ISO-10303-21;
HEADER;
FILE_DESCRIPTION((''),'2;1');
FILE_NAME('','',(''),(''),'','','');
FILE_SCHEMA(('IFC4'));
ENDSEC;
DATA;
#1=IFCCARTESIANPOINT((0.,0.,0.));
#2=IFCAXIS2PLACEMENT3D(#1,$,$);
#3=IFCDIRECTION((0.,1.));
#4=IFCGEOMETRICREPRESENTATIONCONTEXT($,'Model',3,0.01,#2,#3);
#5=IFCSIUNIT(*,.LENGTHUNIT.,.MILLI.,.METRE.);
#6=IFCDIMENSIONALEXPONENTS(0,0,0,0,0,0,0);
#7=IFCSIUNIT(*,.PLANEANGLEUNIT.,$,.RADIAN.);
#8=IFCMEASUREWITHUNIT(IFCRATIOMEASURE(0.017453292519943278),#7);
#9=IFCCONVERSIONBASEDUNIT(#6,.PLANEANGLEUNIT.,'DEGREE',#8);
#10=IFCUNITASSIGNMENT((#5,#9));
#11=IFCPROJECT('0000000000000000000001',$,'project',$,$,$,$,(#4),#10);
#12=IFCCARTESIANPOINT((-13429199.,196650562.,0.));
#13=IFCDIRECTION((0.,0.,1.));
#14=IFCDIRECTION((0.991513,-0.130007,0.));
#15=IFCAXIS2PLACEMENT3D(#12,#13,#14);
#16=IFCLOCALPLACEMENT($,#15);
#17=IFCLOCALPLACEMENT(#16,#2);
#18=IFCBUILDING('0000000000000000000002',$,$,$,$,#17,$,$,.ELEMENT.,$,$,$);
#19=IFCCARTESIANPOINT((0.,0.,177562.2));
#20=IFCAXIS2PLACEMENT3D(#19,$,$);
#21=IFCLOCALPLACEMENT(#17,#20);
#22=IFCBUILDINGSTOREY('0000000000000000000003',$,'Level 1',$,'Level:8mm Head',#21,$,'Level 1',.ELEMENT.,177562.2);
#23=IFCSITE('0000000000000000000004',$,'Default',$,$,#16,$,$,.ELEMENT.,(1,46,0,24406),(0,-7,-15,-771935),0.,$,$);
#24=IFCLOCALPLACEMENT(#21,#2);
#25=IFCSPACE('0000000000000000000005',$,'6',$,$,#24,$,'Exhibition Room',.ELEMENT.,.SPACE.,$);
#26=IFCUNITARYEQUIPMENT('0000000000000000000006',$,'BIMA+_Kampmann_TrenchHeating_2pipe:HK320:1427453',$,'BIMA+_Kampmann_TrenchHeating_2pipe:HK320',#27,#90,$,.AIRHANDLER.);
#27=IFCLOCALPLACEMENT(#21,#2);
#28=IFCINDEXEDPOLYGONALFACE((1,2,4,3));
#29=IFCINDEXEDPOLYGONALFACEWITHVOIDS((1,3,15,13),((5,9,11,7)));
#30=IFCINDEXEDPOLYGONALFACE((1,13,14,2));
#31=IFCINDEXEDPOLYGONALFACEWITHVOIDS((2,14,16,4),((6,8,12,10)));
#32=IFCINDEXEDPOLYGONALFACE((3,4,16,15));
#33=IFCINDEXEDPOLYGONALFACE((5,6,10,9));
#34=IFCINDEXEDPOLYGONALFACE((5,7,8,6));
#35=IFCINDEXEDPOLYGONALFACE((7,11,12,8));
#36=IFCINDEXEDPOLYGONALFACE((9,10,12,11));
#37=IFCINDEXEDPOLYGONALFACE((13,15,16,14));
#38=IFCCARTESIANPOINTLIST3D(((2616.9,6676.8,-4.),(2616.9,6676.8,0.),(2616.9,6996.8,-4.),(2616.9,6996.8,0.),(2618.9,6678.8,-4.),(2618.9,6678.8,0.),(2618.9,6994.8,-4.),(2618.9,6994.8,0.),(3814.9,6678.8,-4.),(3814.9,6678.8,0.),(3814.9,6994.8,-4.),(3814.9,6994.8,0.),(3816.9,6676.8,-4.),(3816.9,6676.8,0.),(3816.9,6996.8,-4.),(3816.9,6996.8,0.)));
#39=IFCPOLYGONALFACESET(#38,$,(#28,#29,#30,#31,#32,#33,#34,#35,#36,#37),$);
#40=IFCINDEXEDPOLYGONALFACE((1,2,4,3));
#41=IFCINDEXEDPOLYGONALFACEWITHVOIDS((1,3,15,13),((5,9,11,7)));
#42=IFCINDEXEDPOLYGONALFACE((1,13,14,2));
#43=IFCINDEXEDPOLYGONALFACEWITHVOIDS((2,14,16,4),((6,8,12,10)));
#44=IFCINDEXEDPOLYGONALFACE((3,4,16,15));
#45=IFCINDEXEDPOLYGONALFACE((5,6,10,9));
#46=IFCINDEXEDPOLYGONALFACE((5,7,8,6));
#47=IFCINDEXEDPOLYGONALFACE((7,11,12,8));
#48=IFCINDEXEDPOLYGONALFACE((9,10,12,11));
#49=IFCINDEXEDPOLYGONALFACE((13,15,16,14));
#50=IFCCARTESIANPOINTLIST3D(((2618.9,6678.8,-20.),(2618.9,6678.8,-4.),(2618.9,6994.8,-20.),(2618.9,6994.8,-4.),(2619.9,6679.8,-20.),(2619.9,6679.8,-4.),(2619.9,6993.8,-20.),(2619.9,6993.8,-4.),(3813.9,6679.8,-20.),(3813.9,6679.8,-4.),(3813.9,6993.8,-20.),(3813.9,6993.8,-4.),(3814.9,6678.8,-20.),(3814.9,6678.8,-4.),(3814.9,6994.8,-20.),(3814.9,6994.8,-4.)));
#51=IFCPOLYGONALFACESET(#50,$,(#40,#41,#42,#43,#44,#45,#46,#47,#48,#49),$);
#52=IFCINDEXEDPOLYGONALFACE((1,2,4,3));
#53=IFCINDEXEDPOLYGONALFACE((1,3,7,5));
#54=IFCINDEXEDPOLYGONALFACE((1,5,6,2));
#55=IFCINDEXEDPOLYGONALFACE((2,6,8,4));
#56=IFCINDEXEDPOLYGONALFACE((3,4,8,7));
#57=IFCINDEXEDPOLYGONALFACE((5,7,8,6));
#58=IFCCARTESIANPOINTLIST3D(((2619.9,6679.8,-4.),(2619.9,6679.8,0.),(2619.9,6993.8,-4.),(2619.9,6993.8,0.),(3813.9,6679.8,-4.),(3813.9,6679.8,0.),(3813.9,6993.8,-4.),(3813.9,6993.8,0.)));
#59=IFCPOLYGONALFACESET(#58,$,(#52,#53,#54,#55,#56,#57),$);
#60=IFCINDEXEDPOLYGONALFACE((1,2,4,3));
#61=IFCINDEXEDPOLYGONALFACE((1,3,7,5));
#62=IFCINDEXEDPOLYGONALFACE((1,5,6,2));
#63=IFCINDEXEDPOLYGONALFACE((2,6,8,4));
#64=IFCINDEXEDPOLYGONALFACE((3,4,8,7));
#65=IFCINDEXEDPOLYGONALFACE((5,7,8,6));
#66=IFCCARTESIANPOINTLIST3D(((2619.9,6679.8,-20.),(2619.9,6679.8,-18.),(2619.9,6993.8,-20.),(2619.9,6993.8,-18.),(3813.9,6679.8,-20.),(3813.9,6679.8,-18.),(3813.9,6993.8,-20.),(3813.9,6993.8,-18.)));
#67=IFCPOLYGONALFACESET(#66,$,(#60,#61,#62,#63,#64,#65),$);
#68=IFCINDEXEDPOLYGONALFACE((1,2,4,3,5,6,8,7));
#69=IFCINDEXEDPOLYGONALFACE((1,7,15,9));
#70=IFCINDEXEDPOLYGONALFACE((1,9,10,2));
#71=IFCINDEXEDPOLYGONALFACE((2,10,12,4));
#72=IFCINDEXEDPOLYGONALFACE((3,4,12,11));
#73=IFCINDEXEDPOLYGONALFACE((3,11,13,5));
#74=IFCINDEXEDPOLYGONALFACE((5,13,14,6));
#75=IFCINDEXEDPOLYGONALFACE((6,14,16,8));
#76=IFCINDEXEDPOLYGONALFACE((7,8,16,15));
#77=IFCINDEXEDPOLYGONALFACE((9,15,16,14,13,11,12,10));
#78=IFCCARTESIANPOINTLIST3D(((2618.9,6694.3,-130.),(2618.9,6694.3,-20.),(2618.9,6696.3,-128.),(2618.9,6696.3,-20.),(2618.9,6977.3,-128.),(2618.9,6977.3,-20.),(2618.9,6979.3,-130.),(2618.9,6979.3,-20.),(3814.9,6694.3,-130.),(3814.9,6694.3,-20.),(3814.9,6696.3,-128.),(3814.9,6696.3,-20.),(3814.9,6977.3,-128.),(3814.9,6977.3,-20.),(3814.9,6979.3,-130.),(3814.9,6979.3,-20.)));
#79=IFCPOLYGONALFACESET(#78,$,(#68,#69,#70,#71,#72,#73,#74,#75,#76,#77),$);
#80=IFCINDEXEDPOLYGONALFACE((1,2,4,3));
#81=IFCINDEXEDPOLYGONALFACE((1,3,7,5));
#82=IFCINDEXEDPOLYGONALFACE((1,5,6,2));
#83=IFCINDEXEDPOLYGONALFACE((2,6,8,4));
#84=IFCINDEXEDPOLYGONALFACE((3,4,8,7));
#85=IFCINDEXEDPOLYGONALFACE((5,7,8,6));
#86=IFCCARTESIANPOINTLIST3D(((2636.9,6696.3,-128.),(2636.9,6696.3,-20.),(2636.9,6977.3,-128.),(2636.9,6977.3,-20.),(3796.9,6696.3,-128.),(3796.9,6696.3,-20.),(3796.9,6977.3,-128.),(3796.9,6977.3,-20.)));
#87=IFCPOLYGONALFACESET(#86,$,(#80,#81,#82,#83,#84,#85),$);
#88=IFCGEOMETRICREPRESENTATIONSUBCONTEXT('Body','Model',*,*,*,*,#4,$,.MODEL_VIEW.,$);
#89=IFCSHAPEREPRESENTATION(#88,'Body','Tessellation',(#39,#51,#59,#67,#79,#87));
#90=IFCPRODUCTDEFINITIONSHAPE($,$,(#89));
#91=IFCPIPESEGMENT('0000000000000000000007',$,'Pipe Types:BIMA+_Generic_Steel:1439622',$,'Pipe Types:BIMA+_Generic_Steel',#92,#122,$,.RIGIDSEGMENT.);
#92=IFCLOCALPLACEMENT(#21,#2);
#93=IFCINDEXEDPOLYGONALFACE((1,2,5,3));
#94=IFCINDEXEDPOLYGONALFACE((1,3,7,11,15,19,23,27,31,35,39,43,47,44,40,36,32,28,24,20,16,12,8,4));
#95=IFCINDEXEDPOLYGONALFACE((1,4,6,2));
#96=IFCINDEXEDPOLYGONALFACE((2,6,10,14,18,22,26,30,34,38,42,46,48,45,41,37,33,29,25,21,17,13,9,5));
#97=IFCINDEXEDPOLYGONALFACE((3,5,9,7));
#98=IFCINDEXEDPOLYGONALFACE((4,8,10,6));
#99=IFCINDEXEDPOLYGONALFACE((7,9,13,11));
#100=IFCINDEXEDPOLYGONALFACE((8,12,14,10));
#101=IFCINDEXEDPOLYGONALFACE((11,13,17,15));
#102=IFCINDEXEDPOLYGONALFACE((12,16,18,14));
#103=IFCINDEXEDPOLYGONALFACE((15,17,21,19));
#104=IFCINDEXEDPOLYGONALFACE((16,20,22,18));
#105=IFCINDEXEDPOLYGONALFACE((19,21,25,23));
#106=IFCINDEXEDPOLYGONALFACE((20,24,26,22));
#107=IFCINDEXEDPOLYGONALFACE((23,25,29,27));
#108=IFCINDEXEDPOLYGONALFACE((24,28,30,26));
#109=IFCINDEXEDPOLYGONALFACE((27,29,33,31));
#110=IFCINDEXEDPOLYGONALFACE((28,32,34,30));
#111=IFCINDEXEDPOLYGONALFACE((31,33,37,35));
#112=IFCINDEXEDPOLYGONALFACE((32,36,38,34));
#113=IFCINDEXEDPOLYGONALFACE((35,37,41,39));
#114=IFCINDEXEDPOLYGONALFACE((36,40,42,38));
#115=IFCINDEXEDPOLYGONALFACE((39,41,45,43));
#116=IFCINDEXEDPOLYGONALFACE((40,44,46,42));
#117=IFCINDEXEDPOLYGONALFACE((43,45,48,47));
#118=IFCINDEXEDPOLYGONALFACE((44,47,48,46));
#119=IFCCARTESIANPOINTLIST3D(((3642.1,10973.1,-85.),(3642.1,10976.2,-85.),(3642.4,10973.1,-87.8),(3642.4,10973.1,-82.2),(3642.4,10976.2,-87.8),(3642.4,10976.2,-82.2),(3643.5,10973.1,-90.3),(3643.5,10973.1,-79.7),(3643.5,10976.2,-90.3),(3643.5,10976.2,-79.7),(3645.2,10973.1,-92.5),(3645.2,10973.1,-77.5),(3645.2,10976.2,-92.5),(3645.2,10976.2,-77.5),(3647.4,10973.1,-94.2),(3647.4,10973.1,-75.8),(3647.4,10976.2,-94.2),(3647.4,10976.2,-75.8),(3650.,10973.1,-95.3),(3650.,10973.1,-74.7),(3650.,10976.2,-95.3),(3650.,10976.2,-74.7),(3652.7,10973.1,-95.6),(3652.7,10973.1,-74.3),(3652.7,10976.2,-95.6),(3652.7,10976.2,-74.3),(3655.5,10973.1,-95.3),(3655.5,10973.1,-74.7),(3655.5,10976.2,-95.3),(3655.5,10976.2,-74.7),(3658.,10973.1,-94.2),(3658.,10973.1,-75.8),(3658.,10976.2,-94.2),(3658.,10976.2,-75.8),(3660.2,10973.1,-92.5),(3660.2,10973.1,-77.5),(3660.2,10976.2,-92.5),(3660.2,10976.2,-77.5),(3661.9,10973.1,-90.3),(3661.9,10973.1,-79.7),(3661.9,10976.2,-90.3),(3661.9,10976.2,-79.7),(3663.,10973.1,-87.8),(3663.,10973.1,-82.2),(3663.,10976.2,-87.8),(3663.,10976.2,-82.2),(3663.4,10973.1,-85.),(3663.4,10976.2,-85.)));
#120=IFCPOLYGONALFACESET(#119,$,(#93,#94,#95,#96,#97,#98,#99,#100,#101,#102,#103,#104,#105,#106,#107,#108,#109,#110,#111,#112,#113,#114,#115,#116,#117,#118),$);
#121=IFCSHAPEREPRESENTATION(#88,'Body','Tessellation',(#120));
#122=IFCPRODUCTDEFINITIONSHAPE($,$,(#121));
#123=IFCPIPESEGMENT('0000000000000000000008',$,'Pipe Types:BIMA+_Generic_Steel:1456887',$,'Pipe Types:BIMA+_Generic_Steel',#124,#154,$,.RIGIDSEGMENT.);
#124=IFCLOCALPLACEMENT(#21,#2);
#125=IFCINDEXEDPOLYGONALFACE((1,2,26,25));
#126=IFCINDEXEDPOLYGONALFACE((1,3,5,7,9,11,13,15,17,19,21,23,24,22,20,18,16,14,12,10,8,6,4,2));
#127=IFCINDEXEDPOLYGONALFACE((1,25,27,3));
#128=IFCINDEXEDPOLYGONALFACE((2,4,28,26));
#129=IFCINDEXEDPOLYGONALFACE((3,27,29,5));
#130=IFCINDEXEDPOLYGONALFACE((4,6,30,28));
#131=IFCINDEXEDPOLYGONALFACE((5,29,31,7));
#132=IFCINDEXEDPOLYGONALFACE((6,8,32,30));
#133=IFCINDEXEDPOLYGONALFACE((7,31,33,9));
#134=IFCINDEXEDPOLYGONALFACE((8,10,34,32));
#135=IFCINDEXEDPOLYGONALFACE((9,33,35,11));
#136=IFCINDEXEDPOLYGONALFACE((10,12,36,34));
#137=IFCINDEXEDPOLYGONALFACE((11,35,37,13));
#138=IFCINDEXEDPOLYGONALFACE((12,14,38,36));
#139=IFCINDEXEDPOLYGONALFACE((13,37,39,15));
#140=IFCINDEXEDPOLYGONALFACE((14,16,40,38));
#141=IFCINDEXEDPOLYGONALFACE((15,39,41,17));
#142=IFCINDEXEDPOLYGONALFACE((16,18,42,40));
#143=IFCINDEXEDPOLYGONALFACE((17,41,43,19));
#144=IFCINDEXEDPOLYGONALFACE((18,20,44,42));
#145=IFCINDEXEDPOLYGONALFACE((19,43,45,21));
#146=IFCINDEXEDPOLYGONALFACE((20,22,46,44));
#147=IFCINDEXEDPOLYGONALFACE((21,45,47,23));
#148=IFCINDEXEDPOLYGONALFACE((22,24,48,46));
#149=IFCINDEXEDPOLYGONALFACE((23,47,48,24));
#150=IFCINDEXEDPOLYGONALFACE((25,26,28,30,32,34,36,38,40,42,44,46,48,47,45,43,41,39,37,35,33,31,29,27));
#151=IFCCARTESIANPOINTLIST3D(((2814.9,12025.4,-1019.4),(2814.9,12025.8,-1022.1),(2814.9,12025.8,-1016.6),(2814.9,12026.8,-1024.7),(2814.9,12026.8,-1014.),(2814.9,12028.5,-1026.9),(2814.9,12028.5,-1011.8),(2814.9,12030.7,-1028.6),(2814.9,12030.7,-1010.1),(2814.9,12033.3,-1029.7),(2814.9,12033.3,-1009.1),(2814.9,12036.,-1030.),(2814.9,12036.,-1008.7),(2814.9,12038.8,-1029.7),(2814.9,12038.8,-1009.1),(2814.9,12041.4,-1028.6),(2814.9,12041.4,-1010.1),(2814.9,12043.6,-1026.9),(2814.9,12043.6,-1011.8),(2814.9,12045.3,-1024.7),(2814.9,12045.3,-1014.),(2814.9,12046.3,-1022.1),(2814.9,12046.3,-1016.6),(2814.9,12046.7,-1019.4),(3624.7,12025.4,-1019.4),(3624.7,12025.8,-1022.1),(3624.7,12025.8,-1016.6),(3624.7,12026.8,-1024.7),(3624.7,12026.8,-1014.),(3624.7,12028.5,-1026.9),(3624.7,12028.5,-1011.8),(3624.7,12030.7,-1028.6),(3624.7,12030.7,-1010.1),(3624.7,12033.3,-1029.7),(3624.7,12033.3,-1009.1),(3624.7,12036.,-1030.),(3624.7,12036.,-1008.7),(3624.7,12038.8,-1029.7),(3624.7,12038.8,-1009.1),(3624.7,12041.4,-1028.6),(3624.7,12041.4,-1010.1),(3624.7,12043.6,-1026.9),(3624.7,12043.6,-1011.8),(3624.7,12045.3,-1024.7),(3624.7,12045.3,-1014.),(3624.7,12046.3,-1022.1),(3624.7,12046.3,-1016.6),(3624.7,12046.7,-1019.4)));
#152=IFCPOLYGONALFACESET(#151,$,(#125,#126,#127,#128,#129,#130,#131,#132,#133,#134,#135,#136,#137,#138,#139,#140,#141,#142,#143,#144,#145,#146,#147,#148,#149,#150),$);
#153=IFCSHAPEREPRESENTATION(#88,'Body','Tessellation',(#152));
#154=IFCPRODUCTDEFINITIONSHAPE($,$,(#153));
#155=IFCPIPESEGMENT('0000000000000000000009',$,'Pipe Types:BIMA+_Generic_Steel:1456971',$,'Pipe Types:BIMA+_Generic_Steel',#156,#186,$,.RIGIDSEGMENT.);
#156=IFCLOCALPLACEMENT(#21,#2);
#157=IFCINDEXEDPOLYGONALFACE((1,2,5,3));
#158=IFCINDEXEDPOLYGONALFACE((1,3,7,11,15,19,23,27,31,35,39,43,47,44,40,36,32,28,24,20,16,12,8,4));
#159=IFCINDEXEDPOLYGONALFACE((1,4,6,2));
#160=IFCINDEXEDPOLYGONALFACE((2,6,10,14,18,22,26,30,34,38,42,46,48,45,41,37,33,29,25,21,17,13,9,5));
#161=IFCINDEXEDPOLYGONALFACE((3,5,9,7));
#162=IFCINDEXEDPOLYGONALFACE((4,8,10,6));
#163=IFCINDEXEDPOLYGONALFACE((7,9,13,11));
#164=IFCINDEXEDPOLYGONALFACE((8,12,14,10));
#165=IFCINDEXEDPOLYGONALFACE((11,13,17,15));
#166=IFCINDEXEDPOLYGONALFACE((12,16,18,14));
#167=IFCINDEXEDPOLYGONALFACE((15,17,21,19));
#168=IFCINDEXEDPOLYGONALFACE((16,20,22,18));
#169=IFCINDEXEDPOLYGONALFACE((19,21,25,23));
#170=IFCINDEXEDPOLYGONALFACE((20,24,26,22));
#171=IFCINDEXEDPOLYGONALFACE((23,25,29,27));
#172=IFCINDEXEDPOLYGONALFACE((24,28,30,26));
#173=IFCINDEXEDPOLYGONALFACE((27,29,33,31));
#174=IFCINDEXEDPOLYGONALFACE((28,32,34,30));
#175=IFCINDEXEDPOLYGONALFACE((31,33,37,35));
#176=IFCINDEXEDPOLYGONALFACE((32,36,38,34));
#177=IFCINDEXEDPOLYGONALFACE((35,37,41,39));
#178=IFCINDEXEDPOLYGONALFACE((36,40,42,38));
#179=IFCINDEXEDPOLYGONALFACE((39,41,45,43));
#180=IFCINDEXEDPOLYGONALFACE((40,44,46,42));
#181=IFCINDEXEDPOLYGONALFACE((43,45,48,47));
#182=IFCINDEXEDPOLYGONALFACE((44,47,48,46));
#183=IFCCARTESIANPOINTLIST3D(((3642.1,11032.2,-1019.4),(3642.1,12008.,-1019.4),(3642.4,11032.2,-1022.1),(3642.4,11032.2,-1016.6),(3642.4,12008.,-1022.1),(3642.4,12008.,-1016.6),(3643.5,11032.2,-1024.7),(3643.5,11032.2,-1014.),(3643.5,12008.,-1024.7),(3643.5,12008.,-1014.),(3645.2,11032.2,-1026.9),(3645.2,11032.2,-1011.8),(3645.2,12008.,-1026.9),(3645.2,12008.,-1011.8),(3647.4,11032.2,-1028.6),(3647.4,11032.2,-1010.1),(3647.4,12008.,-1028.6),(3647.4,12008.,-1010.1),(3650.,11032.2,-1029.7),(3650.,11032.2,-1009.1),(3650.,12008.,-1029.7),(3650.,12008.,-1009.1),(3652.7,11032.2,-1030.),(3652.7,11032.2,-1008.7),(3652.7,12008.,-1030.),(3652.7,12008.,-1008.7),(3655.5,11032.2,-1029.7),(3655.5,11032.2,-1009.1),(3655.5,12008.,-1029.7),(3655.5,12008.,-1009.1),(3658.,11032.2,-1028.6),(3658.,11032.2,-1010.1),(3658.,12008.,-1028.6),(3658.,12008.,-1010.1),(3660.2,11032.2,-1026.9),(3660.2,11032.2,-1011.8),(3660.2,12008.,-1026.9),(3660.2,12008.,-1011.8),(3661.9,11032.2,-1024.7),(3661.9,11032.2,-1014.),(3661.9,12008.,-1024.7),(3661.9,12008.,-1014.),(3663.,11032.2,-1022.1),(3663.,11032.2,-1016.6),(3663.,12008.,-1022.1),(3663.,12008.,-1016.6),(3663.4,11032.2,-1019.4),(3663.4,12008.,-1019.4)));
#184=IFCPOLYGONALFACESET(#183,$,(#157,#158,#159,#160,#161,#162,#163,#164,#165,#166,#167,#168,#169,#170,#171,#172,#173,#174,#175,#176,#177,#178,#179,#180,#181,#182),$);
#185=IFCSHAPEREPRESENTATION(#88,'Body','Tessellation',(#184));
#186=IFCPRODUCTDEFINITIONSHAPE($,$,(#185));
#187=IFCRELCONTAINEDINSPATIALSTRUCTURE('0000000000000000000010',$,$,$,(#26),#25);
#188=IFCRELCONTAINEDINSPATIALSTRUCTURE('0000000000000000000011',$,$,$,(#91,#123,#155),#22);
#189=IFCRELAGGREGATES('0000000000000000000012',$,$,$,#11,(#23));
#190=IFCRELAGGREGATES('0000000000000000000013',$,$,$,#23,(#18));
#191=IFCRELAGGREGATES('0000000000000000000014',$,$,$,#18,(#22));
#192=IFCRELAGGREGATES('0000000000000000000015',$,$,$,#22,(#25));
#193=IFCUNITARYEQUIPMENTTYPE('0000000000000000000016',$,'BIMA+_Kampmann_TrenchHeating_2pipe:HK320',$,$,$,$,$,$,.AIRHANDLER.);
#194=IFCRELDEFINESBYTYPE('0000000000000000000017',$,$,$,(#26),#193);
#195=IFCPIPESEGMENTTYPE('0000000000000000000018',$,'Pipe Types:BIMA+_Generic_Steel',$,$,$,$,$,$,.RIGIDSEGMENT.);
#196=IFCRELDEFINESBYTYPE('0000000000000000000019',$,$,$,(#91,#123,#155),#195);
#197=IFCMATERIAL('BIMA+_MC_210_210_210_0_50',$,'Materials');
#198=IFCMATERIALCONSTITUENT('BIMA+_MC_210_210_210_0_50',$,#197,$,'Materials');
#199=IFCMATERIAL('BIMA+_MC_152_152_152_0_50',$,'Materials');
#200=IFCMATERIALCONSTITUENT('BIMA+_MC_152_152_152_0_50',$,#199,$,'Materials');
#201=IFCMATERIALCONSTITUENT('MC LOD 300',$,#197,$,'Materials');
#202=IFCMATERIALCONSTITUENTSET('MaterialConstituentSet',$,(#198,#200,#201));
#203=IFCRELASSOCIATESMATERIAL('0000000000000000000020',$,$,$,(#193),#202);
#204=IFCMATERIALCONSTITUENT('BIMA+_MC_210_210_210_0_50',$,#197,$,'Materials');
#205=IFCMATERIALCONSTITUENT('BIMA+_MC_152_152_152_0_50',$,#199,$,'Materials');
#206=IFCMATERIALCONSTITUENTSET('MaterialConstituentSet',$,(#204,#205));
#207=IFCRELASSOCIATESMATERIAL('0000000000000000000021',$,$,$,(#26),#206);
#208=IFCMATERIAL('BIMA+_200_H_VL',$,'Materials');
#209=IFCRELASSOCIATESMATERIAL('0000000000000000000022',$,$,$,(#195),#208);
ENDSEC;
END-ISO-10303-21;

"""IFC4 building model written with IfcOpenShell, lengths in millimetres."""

from ifc_helpers import new_model, entity, si_unit, converted_unit, direction, frame, origin, place, context, subcontext, project, spatial, arc, indexed_curve, outline, extrude, source, transform, mapped, material, constituent, constituent_set, type_object, type_shapes, element, save


model = new_model("IFC4")

# Units and contexts
model_context = context("Model", 3, precision=0.01, world=origin(), true_north=direction((0.0, 1.0)))
body_context = subcontext(model_context, "Body", "Model", "MODEL_VIEW")
ifc_project = project(units=[si_unit("LENGTHUNIT", "METRE", prefix="MILLI"), converted_unit("PLANEANGLEUNIT", "DEGREE", entity("IfcRatioMeasure", 0.017453292519943278), si_unit("PLANEANGLEUNIT", "RADIAN"), dimensions=[0, 0, 0, 0, 0, 0, 0])], contexts=[model_context])

# Site, building, storey
site_placement = place(None, frame((-13429199.0, 196650562.0, 0.0), z_axis=(0.0, 0.0, 1.0), x_axis=(0.991513, -0.130007, 0.0)))
site = spatial("IfcSite", under=ifc_project, at=site_placement, Name="Default", CompositionType="ELEMENT", RefLatitude=(1, 46, 0, 24406), RefLongitude=(0, -7, -15, -771935), RefElevation=0.0)
building_placement = place(site_placement, origin())
building = spatial("IfcBuilding", under=site, at=building_placement, CompositionType="ELEMENT")
storey_placement = place(building_placement, frame((0.0, 0.0, 177562.2)))
storey = spatial("IfcBuildingStorey", under=building, at=storey_placement, Name="Level 1", ObjectType="Level:8mm Head", LongName="Level 1", CompositionType="ELEMENT", Elevation=177562.2)

# Shared definitions
space_placement = place(storey_placement, origin())
space = spatial("IfcSpace", under=storey, at=space_placement, Name="6", LongName="Exhibition Room", CompositionType="ELEMENT", PredefinedType="SPACE")

# Unitary equipment
ifc_material_1 = material(Name="BIMA+_MC_210_210_210_0_50", Category="Materials")
ifc_material_2 = material(Name="BIMA+_MC_152_152_152_0_50", Category="Materials")
ifc_constituent_1 = constituent(ifc_material_1, Name="BIMA+_MC_210_210_210_0_50", Category="Materials")
ifc_constituent_2 = constituent(ifc_material_2, Name="BIMA+_MC_152_152_152_0_50", Category="Materials")
ifc_constituent_3 = constituent(ifc_material_1, Name="MC LOD 300", Category="Materials")
ifc_constituent_set_1 = constituent_set(constituents=[ifc_constituent_1, ifc_constituent_2, ifc_constituent_3], Name="MaterialConstituentSet")
unitary_equipment_type = type_object("IfcUnitaryEquipmentType", Name="BIMA+_Kampmann_TrenchHeating_2pipe:HK320", PredefinedType="AIRHANDLER", material=ifc_constituent_set_1)
shared_shape = source(origin(), body_context, "Body", "SweptSolid", [
    extrude(outline(indexed_curve([(-160.0, -600.0), (160.0, -600.0), (160.0, 600.0), (-160.0, 600.0), (-160.0, -600.0)], self_intersect=False), holes=[indexed_curve([(-158.0, 598.0), (158.0, 598.0), (158.0, -598.0), (-158.0, -598.0), (-158.0, 598.0)], self_intersect=False)]), frame((0.0, 0.0, -4.0), z_axis=(0.0, 0.0, 1.0), x_axis=(0.0, -1.0, 0.0)), (0.0, 0.0, 1.0), 4.0),
    extrude(outline(indexed_curve([(-598.0, -158.0), (598.0, -158.0), (598.0, 158.0), (-598.0, 158.0), (-598.0, -158.0)], self_intersect=False), holes=[indexed_curve([(-597.0, -157.0), (-597.0, 157.0), (597.0, 157.0), (597.0, -157.0), (-597.0, -157.0)], self_intersect=False)]), frame((0.0, 0.0, -20.0), z_axis=(0.0, 0.0, 1.0), x_axis=(-1.0, 0.0, 0.0)), (0.0, 0.0, 1.0), 16.0),
    extrude(outline(indexed_curve([(-597.0, -157.0), (597.0, -157.0), (597.0, 157.0), (-597.0, 157.0), (-597.0, -157.0)], self_intersect=False)), frame((0.0, 0.0, -4.0), z_axis=(0.0, 0.0, 1.0), x_axis=(-1.0, 0.0, 0.0)), (0.0, 0.0, 1.0), 4.0),
    extrude(outline(indexed_curve([(-597.0, -157.0), (597.0, -157.0), (597.0, 157.0), (-597.0, 157.0), (-597.0, -157.0)], self_intersect=False)), frame((0.0, 0.0, -20.0), z_axis=(0.0, 0.0, 1.0), x_axis=(-1.0, 0.0, 0.0)), (0.0, 0.0, 1.0), 2.0),
    extrude(outline(indexed_curve([(-55.5, -142.5), (54.5, -142.5), (54.5, -140.5), (-53.5, -140.5), (-53.5, 140.5), (54.5, 140.5), (54.5, 142.5), (-55.5, 142.5), (-55.5, -142.5)], self_intersect=False)), frame((-598.0, 0.0, -74.5), z_axis=(1.0, 0.0, 0.0), x_axis=(0.0, 0.0, 1.0)), (0.0, 0.0, 1.0), 1196.0),
    extrude(outline(indexed_curve([(-580.0, -140.5), (580.0, -140.5), (580.0, 140.5), (-580.0, 140.5), (-580.0, -140.5)], self_intersect=False)), frame((0.0, 0.0, -128.0), z_axis=(0.0, 0.0, 1.0), x_axis=(-1.0, 0.0, 0.0)), (0.0, 0.0, 1.0), 108.0),
])
type_shapes(unitary_equipment_type, [shared_shape])
ifc_constituent_4 = constituent(ifc_material_1, Name="BIMA+_MC_210_210_210_0_50", Category="Materials")
ifc_constituent_5 = constituent(ifc_material_2, Name="BIMA+_MC_152_152_152_0_50", Category="Materials")
ifc_constituent_set_2 = constituent_set(constituents=[ifc_constituent_4, ifc_constituent_5], Name="MaterialConstituentSet")
unitary_equipment_1_placement = place(space_placement, frame((3216.9, 6836.8, 0.0)))
element("IfcUnitaryEquipment", 1, at=unitary_equipment_1_placement, inside=space, type_object=unitary_equipment_type, material=ifc_constituent_set_2, Name="BIMA+_Kampmann_TrenchHeating_2pipe:HK320:1427453", ObjectType="BIMA+_Kampmann_TrenchHeating_2pipe:HK320", PredefinedType="AIRHANDLER", context=body_context, shape_type="MappedRepresentation", body=[
    mapped(shared_shape, transform((0.0, 0.0, 0.0), scale=1.0)),
])

# Pipe segments
ifc_material_3 = material(Name="BIMA+_200_H_VL", Category="Materials")
pipe_segment_type_1 = type_object("IfcPipeSegmentType", Name="Pipe Types:BIMA+_Generic_Steel", PredefinedType="RIGIDSEGMENT", material=ifc_material_3)
pipe_segment_1_placement = place(storey_placement, frame((3640.5, 10973.1, -97.2)))
element("IfcPipeSegment", 2, at=pipe_segment_1_placement, inside=storey, type_object=pipe_segment_type_1, Name="Pipe Types:BIMA+_Generic_Steel:1439622", ObjectType="Pipe Types:BIMA+_Generic_Steel", PredefinedType="RIGIDSEGMENT", context=body_context, shape_type="SweptSolid", body=[
    extrude(outline(indexed_curve([(10.6, 0.0), (7.5, 7.5), (0.0, 10.7), (-7.5, 7.5), (-10.6, 0.0), (-7.5, -7.5), (0.0, -10.7), (7.5, -7.5)], segments=[arc(1, 2, 3), arc(3, 4, 5), arc(5, 6, 7), arc(7, 8, 1)], self_intersect=False)), frame((12.2, 0.0, 12.2), z_axis=(0.0, 1.0, 0.0), x_axis=(1.0, 0.0, 0.0)), (0.0, 0.0, 1.0), 3.1),
])
pipe_segment_2_placement = place(storey_placement, frame((2814.9, 12023.8, -1031.6)))
element("IfcPipeSegment", 3, at=pipe_segment_2_placement, inside=storey, type_object=pipe_segment_type_1, Name="Pipe Types:BIMA+_Generic_Steel:1456887", ObjectType="Pipe Types:BIMA+_Generic_Steel", PredefinedType="RIGIDSEGMENT", context=body_context, shape_type="SweptSolid", body=[
    extrude(outline(indexed_curve([(10.6, 0.0), (7.5, 7.5), (0.0, 10.7), (-7.5, 7.5), (-10.6, 0.0), (-7.5, -7.5), (0.0, -10.7), (7.5, -7.5)], segments=[arc(1, 2, 3), arc(3, 4, 5), arc(5, 6, 7), arc(7, 8, 1)], self_intersect=False)), frame((0.0, 12.2, 12.2), z_axis=(1.0, 0.0, 0.0), x_axis=(0.0, -1.0, 0.0)), (0.0, 0.0, 1.0), 809.9),
])
pipe_segment_3_placement = place(storey_placement, frame((3640.5, 11032.2, -1031.6)))
element("IfcPipeSegment", 4, at=pipe_segment_3_placement, inside=storey, type_object=pipe_segment_type_1, Name="Pipe Types:BIMA+_Generic_Steel:1456971", ObjectType="Pipe Types:BIMA+_Generic_Steel", PredefinedType="RIGIDSEGMENT", context=body_context, shape_type="SweptSolid", body=[
    extrude(outline(indexed_curve([(10.6, 0.0), (7.5, 7.5), (0.0, 10.7), (-7.5, 7.5), (-10.7, 0.0), (-7.5, -7.5), (0.0, -10.7), (7.5, -7.5)], segments=[arc(1, 2, 3), arc(3, 4, 5), arc(5, 6, 7), arc(7, 8, 1)], self_intersect=False)), frame((12.2, 0.0, 12.2), z_axis=(0.0, 1.0, 0.0), x_axis=(-1.0, 0.0, 0.0)), (0.0, 0.0, 1.0), 975.9),
])

save(model, "model.ifc")
